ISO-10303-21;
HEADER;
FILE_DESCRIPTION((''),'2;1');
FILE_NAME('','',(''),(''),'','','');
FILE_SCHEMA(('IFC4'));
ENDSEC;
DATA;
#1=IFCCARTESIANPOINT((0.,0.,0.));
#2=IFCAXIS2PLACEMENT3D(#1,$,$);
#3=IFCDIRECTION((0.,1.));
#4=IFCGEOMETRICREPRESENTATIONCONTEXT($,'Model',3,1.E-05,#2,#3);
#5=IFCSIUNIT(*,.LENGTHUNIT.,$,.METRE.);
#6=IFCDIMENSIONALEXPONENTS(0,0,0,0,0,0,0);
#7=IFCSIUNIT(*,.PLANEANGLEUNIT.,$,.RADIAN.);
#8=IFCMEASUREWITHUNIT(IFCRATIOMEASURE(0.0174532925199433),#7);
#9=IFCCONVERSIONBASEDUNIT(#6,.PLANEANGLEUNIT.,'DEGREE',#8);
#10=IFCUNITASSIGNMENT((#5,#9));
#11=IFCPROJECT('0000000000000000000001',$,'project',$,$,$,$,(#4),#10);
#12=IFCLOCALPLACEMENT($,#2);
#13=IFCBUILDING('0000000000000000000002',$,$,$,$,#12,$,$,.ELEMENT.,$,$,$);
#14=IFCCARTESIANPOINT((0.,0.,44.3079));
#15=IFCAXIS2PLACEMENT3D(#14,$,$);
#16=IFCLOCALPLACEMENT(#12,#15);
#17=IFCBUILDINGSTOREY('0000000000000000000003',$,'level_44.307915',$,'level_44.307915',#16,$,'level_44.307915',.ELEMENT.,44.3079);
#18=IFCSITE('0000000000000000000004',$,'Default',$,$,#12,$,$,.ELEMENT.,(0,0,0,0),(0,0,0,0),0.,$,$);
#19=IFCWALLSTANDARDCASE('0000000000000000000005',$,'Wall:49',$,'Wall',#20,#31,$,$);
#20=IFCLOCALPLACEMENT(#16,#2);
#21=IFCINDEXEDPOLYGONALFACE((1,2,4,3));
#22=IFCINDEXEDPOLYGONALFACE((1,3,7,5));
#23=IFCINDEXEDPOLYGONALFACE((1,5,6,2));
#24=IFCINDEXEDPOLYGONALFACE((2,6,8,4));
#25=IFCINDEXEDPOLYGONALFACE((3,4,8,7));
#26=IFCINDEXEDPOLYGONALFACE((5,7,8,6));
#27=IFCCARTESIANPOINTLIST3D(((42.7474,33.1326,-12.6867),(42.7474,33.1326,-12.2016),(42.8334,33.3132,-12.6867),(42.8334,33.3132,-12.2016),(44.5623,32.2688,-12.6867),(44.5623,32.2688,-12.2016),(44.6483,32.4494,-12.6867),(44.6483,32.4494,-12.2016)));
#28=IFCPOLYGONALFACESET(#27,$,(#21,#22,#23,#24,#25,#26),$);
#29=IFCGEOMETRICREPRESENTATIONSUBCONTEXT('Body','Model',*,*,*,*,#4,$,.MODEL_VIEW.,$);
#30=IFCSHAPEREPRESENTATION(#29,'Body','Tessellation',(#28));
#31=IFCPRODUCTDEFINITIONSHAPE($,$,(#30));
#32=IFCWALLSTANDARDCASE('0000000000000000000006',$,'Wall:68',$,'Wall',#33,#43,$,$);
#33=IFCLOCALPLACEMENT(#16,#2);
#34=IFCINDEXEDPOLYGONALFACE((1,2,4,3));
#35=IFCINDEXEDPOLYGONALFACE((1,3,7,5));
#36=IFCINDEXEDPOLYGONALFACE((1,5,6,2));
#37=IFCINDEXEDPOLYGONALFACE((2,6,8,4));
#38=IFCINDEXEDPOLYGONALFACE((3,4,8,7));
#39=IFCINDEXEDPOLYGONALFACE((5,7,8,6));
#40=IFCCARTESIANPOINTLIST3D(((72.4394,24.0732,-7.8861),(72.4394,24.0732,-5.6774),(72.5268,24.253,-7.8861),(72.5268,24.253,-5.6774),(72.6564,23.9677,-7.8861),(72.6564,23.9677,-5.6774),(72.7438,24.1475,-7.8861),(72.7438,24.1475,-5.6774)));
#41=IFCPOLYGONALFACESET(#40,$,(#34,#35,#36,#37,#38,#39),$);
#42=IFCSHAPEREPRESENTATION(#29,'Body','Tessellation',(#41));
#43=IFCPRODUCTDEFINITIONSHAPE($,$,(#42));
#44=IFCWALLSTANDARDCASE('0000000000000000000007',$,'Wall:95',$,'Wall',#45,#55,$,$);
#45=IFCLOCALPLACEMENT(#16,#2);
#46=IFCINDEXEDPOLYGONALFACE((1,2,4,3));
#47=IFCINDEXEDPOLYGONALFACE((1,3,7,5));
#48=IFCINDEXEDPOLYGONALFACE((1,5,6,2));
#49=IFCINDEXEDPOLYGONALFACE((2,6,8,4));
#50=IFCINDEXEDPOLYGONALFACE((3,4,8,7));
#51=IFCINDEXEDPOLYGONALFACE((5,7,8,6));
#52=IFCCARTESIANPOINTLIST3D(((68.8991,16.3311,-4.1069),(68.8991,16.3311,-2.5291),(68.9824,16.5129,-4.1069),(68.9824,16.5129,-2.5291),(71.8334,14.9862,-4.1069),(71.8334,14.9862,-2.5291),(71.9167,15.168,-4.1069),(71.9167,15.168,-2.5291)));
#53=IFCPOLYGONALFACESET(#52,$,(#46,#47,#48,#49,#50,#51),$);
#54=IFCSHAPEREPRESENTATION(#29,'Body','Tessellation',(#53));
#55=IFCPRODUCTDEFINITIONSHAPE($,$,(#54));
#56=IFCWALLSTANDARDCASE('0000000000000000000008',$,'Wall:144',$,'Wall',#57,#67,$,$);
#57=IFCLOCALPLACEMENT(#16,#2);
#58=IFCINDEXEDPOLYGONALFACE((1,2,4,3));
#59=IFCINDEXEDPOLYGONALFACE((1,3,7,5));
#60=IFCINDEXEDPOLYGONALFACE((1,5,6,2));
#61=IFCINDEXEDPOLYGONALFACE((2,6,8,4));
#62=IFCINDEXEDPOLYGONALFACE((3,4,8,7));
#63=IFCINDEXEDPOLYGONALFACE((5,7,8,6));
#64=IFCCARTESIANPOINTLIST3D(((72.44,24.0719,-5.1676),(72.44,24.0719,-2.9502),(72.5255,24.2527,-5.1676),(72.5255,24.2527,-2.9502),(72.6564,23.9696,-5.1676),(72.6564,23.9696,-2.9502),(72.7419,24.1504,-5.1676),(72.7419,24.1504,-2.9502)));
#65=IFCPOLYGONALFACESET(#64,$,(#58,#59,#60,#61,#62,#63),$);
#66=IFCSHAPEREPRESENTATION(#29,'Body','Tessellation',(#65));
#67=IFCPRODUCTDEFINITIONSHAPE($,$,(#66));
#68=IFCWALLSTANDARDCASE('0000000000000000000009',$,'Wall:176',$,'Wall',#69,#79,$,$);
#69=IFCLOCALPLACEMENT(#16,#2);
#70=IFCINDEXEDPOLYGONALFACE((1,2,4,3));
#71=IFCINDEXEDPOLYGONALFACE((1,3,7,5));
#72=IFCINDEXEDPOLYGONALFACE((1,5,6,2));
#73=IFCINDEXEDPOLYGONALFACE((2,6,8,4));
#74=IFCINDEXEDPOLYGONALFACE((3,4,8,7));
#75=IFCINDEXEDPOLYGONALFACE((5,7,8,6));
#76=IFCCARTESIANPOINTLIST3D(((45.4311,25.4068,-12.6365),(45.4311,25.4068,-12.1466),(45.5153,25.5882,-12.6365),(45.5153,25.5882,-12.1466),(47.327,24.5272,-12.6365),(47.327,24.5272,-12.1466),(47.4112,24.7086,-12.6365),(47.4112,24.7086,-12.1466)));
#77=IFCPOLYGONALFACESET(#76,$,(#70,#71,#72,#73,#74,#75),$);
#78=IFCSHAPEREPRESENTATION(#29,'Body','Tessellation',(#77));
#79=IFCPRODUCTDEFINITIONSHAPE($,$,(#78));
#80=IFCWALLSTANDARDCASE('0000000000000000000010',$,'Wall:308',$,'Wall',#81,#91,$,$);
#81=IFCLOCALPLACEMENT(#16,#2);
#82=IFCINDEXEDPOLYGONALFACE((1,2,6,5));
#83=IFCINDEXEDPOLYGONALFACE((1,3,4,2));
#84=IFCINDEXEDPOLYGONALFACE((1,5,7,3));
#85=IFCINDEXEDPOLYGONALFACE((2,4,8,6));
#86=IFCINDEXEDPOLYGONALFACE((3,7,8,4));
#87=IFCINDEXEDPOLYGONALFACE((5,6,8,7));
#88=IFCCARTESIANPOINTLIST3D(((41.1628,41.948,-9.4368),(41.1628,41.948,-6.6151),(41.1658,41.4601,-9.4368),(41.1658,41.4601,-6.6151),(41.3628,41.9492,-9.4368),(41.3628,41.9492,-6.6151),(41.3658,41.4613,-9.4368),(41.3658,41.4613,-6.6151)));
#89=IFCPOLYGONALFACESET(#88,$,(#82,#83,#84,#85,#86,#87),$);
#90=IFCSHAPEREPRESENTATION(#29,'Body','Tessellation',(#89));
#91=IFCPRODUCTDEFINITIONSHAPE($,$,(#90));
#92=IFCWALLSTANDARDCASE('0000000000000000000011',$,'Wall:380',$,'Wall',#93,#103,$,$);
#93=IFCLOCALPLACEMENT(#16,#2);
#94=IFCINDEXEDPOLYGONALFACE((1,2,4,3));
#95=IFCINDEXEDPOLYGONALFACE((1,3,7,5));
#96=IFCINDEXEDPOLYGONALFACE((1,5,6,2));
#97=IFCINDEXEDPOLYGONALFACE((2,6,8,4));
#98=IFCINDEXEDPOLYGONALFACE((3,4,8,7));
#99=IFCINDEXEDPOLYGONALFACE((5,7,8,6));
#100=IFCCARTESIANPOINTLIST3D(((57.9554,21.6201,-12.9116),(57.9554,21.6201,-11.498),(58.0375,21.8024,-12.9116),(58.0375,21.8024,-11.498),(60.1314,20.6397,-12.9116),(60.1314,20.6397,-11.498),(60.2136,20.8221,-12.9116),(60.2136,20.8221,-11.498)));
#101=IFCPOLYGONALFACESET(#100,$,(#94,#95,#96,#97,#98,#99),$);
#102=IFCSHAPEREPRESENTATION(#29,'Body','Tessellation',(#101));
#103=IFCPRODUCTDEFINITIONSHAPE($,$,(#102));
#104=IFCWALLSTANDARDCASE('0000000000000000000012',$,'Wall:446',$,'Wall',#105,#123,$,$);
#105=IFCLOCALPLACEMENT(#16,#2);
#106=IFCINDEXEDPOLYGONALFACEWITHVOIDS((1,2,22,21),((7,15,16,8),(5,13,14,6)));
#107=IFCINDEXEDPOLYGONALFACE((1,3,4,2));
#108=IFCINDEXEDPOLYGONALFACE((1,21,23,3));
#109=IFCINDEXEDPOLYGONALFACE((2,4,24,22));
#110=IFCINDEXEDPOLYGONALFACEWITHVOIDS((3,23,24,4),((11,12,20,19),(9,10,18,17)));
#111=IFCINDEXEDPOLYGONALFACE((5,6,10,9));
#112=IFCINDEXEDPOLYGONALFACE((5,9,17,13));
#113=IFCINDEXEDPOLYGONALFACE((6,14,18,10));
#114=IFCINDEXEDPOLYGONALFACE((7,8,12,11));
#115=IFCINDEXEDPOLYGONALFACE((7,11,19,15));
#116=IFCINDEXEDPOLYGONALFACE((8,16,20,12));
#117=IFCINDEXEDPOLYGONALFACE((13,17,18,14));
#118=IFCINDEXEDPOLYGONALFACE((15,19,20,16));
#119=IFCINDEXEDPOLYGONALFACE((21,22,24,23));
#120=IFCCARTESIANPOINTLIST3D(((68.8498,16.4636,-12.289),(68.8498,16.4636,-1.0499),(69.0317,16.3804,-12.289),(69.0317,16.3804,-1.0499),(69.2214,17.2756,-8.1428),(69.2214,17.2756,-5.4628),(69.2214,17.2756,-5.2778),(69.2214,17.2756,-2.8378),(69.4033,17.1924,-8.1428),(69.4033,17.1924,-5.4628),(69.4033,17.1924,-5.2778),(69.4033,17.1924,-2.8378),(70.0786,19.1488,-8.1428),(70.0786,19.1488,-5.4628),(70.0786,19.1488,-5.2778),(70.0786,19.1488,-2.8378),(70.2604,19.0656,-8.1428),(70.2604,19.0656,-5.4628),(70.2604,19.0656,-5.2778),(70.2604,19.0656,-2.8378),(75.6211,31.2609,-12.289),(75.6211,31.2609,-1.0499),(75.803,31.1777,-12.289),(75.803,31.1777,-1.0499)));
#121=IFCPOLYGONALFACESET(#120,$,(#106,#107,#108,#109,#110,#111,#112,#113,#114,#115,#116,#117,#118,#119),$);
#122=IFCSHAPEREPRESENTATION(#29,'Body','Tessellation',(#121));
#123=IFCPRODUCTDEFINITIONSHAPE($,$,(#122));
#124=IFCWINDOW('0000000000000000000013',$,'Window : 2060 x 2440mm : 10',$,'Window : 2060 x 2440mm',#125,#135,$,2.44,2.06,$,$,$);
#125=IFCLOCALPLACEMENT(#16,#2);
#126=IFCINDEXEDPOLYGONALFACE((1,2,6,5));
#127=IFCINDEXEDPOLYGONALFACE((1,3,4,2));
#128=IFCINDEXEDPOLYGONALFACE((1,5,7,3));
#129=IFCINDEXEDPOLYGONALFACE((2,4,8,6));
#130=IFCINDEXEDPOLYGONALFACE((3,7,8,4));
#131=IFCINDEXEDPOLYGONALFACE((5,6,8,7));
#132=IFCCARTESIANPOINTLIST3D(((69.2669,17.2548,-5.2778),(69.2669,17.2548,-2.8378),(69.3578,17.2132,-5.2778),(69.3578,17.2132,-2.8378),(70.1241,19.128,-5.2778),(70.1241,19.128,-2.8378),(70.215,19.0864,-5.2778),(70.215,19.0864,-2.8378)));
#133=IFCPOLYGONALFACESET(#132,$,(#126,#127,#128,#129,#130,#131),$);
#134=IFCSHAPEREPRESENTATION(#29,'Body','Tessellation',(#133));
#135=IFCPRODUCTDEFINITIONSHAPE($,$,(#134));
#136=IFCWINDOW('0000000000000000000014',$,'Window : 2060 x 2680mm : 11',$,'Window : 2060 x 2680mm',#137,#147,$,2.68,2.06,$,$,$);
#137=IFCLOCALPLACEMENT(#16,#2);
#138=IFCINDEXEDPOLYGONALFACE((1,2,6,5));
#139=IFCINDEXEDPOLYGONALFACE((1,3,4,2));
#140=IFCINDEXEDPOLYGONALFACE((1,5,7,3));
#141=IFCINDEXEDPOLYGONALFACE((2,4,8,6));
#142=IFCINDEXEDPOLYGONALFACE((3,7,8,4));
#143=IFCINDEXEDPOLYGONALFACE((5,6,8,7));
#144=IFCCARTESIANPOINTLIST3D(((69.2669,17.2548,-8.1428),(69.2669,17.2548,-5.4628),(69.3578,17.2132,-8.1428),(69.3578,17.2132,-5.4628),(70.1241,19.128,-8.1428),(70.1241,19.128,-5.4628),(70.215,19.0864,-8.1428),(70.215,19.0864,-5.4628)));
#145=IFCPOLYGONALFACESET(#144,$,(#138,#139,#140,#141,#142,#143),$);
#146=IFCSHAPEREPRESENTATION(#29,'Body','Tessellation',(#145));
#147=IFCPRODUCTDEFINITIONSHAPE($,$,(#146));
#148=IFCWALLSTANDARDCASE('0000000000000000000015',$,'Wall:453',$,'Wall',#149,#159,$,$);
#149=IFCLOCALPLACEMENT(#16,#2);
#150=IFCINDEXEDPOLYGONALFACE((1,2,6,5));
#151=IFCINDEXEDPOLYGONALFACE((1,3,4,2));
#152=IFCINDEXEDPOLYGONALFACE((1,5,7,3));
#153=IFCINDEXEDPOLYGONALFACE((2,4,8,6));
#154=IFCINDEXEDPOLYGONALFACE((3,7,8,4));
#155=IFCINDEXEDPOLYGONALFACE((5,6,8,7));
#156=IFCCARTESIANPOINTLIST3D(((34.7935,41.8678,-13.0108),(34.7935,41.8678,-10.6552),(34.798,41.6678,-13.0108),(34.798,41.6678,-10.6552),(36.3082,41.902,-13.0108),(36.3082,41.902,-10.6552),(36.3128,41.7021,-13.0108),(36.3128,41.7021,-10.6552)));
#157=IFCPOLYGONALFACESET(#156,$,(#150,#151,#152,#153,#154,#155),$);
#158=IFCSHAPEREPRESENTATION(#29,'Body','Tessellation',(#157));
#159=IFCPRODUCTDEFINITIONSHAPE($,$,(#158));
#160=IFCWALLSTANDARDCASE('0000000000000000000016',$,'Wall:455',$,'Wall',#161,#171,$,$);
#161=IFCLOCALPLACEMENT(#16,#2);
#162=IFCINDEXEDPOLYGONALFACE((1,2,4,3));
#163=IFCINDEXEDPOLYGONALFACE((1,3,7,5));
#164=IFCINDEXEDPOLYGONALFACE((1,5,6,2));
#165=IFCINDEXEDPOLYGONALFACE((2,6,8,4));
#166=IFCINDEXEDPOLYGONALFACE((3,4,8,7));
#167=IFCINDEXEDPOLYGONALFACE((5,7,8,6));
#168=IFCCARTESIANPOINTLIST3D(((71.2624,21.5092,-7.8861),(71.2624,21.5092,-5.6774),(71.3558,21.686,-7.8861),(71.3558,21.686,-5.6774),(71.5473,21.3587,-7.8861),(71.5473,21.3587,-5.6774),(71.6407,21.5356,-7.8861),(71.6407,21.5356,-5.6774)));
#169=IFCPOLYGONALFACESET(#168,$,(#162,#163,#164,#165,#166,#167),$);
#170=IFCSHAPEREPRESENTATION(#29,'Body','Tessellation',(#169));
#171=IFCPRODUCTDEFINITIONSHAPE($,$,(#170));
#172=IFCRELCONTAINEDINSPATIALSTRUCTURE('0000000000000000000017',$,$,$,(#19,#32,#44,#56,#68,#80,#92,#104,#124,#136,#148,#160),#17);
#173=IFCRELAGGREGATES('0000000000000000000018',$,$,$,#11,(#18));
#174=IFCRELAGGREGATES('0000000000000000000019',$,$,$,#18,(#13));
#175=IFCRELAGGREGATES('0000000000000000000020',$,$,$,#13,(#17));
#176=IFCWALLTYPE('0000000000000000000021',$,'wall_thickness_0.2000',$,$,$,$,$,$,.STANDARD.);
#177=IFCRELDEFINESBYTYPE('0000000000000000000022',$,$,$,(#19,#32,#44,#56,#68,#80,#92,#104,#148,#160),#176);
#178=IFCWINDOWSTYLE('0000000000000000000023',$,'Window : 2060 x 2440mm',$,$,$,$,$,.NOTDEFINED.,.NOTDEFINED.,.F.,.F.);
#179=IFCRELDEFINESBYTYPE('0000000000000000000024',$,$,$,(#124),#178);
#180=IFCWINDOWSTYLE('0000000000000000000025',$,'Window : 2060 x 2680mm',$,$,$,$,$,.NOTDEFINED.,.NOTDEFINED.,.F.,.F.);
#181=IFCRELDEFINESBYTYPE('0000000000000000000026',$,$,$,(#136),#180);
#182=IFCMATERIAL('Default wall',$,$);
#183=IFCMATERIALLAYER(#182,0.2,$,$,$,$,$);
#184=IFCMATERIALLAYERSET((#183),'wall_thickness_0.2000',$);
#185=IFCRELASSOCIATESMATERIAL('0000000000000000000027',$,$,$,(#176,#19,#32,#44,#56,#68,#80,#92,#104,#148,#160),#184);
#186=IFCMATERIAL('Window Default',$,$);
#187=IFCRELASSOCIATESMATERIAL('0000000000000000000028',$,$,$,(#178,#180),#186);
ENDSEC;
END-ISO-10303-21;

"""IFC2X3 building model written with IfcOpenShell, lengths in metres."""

from ifc_helpers import new_model, entity, si_unit, converted_unit, direction, frame, frame_2d, origin, origin_2d_with_axis, place, context, subcontext, project, spatial, polyline, rectangle, outline, extrude, source, transform, mapped, material, layer, layer_set, layer_usage, type_object, type_shapes, element, fill, save


model = new_model("IFC2X3")

# Units and contexts
model_context = context("Model", 3, precision=1e-05, world=origin(), true_north=direction((0.0, 1.0)))
body_context = subcontext(model_context, "Body", "Model", "MODEL_VIEW")
ifc_project = project(units=[si_unit("LENGTHUNIT", "METRE"), converted_unit("PLANEANGLEUNIT", "DEGREE", entity("IfcRatioMeasure", 0.0174532925199433), si_unit("PLANEANGLEUNIT", "RADIAN"), dimensions=[0, 0, 0, 0, 0, 0, 0])], contexts=[model_context])

# Site, building, storey
placement_1 = place(None, origin())
site = spatial("IfcSite", under=ifc_project, at=placement_1, Name="Default", CompositionType="ELEMENT", RefLatitude=(0, 0, 0, 0), RefLongitude=(0, 0, 0, 0), RefElevation=0.0)
building = spatial("IfcBuilding", under=site, at=placement_1, CompositionType="ELEMENT")
storey_placement = place(placement_1, frame((0.0, 0.0, 44.3079)))
storey = spatial("IfcBuildingStorey", under=building, at=storey_placement, Name="level_44.307915", ObjectType="level_44.307915", LongName="level_44.307915", CompositionType="ELEMENT", Elevation=44.3079)

# Walls
ifc_material_1 = material(Name="Default wall")
ifc_layer = layer(ifc_material_1, 0.2)
ifc_layer_set = layer_set([ifc_layer], Name="wall_thickness_0.2000")
ifc_layer_usage = layer_usage(ifc_layer_set, "AXIS2", "POSITIVE", -0.1)
wall_type = type_object("IfcWallType", Name="wall_thickness_0.2000", PredefinedType="STANDARD", material=ifc_layer_set)
placement_2 = place(placement_1, frame((0.0, 0.0, 31.6212)))
wall_1_placement = place(placement_2, frame((42.7904, 33.2229, 0.0), z_axis=(0.0, 0.0, 1.0), x_axis=(0.902938, -0.429772, 0.0)))
element("IfcWallStandardCase", 1, at=wall_1_placement, inside=storey, type_object=wall_type, material=ifc_layer_usage, Name="Wall:49", ObjectType="Wall", context=body_context, shape_type="SweptSolid", body=[
    extrude(outline(polyline([(2.01, -0.1), (2.01, 0.1), (0.0, 0.1), (0.0, -0.1), (2.01, -0.1)])), origin(), (0.0, 0.0, 1.0), 0.485),
])
placement_3 = place(placement_1, frame((0.0, 0.0, 36.4218)))
wall_2_placement = place(placement_3, frame((72.4831, 24.1631, 0.0), z_axis=(0.0, 0.0, 1.0), x_axis=(0.899364, -0.4372, 0.0)))
element("IfcWallStandardCase", 2, at=wall_2_placement, inside=storey, type_object=wall_type, material=ifc_layer_usage, Name="Wall:68", ObjectType="Wall", context=body_context, shape_type="SweptSolid", body=[
    extrude(outline(polyline([(0.2413, -0.1), (0.2413, 0.1), (0.0, 0.1), (0.0, -0.1), (0.2413, -0.1)])), origin(), (0.0, 0.0, 1.0), 2.2087),
])
placement_4 = place(placement_1, frame((0.0, 0.0, 40.201)))
wall_3_placement = place(placement_4, frame((68.9408, 16.422, 0.0), z_axis=(0.0, 0.0, 1.0), x_axis=(0.90906, -0.416665, 0.0)))
element("IfcWallStandardCase", 3, at=wall_3_placement, inside=storey, type_object=wall_type, material=ifc_layer_usage, Name="Wall:95", ObjectType="Wall", context=body_context, shape_type="SweptSolid", body=[
    extrude(outline(polyline([(3.2278, -0.1), (3.2278, 0.1), (0.0, 0.1), (0.0, -0.1), (3.2278, -0.1)])), origin(), (0.0, 0.0, 1.0), 1.5778),
])
placement_5 = place(placement_1, frame((0.0, 0.0, 39.1403)))
wall_4_placement = place(placement_5, frame((72.4828, 24.1623, 0.0), z_axis=(0.0, 0.0, 1.0), x_axis=(0.903995, -0.427543, 0.0)))
element("IfcWallStandardCase", 4, at=wall_4_placement, inside=storey, type_object=wall_type, material=ifc_layer_usage, Name="Wall:144", ObjectType="Wall", context=body_context, shape_type="SweptSolid", body=[
    extrude(outline(polyline([(0.2394, -0.1), (0.2394, 0.1), (0.0, 0.1), (0.0, -0.1), (0.2394, -0.1)])), origin(), (0.0, 0.0, 1.0), 2.2174),
])
placement_6 = place(placement_1, frame((0.0, 0.0, 31.6714)))
wall_5_placement = place(placement_6, frame((45.4732, 25.4975, 0.0), z_axis=(0.0, 0.0, 1.0), x_axis=(0.907125, -0.42086, 0.0)))
element("IfcWallStandardCase", 5, at=wall_5_placement, inside=storey, type_object=wall_type, material=ifc_layer_usage, Name="Wall:176", ObjectType="Wall", context=body_context, shape_type="SweptSolid", body=[
    extrude(outline(polyline([(2.09, -0.1), (2.09, 0.1), (0.0, 0.1), (0.0, -0.1), (2.09, -0.1)])), origin(), (0.0, 0.0, 1.0), 0.4899),
])
placement_7 = place(placement_1, frame((0.0, 0.0, 34.8711)))
wall_6_placement = place(placement_7, frame((41.2628, 41.9486, 0.0), z_axis=(0.0, 0.0, 1.0), x_axis=(0.006059, -0.999982, 0.0)))
element("IfcWallStandardCase", 6, at=wall_6_placement, inside=storey, type_object=wall_type, material=ifc_layer_usage, Name="Wall:308", ObjectType="Wall", context=body_context, shape_type="SweptSolid", body=[
    extrude(outline(polyline([(0.4879, -0.1), (0.4879, 0.1), (0.0, 0.1), (0.0, -0.1), (0.4879, -0.1)])), origin(), (0.0, 0.0, 1.0), 2.8217),
])
placement_8 = place(placement_1, frame((0.0, 0.0, 31.3963)))
wall_7_placement = place(placement_8, frame((57.9964, 21.7113, 0.0), z_axis=(0.0, 0.0, 1.0), x_axis=(0.911743, -0.410761, 0.0)))
element("IfcWallStandardCase", 7, at=wall_7_placement, inside=storey, type_object=wall_type, material=ifc_layer_usage, Name="Wall:380", ObjectType="Wall", context=body_context, shape_type="SweptSolid", body=[
    extrude(outline(polyline([(2.3867, -0.1), (2.3867, 0.1), (0.0, 0.1), (0.0, -0.1), (2.3867, -0.1)])), origin(), (0.0, 0.0, 1.0), 1.4136),
])

# Wall, openings, windows
placement_9 = place(placement_1, frame((0.0, 0.0, 32.0189)))
wall_8_placement = place(placement_9, frame((68.9408, 16.422, 0.0), z_axis=(0.0, 0.0, 1.0), x_axis=(0.416104, 0.909317, 0.0)))
wall_8 = element("IfcWallStandardCase", 8, at=wall_8_placement, inside=storey, type_object=wall_type, material=ifc_layer_usage, Name="Wall:446", ObjectType="Wall", context=body_context, shape_type="SweptSolid", body=[
    extrude(outline(polyline([(16.273, -0.1), (16.273, 0.1), (0.0, 0.1), (0.0, -0.1), (16.273, -0.1)])), origin(), (0.0, 0.0, 1.0), 11.2391),
])
opening_1_placement = place(wall_8_placement, frame((0.893, -0.1, 7.0112)))
opening_1 = element("IfcOpeningElement", 9, at=opening_1_placement, cuts=wall_8, ObjectType="Opening", context=body_context, shape_type="SweptSolid", body=[
    extrude(rectangle(XDim=2.06, YDim=2.44, at=frame_2d((1.22, 1.03), x_axis=(0.0, 1.0))), frame((0.0, 0.0, 0.0), z_axis=(0.0, 1.0, 0.0), x_axis=(0.0, 0.0, 1.0)), (0.0, 0.0, 1.0), 0.2),
])
opening_2_placement = place(wall_8_placement, frame((0.893, -0.1, 4.1462)))
opening_2 = element("IfcOpeningElement", 10, at=opening_2_placement, cuts=wall_8, ObjectType="Opening", context=body_context, shape_type="SweptSolid", body=[
    extrude(rectangle(XDim=2.06, YDim=2.68, at=frame_2d((1.34, 1.03), x_axis=(0.0, 1.0))), frame((0.0, 0.0, 0.0), z_axis=(0.0, 1.0, 0.0), x_axis=(0.0, 0.0, 1.0)), (0.0, 0.0, 1.0), 0.2),
])
ifc_material_2 = material(Name="Window Default")
window_style_1 = type_object("IfcWindowStyle", Name="Window : 2060 x 2440mm", ConstructionType="NOTDEFINED", OperationType="NOTDEFINED", ParameterTakesPrecedence=False, Sizeable=False, material=ifc_material_2)
shared_shape_1 = source(origin(), body_context, "Body", "SweptSolid", [
    extrude(rectangle(XDim=0.1, YDim=2.06, at=origin_2d_with_axis()), frame((1.03, 0.1, 0.0), z_axis=(0.0, 0.0, 1.0), x_axis=(0.0, 1.0, 0.0)), (0.0, 0.0, 1.0), 2.44),
])
type_shapes(window_style_1, [shared_shape_1])
window_1_placement = place(opening_1_placement, origin())
window_1 = element("IfcWindow", 11, at=window_1_placement, inside=storey, type_object=window_style_1, Name="Window : 2060 x 2440mm : 10", ObjectType="Window : 2060 x 2440mm", OverallHeight=2.44, OverallWidth=2.06, context=body_context, shape_type="MappedRepresentation", body=[
    mapped(shared_shape_1, transform((0.0, 0.0, 0.0), scale=1.0)),
])
fill(opening_1, window_1)
window_style_2 = type_object("IfcWindowStyle", Name="Window : 2060 x 2680mm", ConstructionType="NOTDEFINED", OperationType="NOTDEFINED", ParameterTakesPrecedence=False, Sizeable=False, material=ifc_material_2)
shared_shape_2 = source(origin(), body_context, "Body", "SweptSolid", [
    extrude(rectangle(XDim=0.1, YDim=2.06, at=origin_2d_with_axis()), frame((1.03, 0.1, 0.0), z_axis=(0.0, 0.0, 1.0), x_axis=(0.0, 1.0, 0.0)), (0.0, 0.0, 1.0), 2.68),
])
type_shapes(window_style_2, [shared_shape_2])
window_2_placement = place(opening_2_placement, origin())
window_2 = element("IfcWindow", 12, at=window_2_placement, inside=storey, type_object=window_style_2, Name="Window : 2060 x 2680mm : 11", ObjectType="Window : 2060 x 2680mm", OverallHeight=2.68, OverallWidth=2.06, context=body_context, shape_type="MappedRepresentation", body=[
    mapped(shared_shape_2, transform((0.0, 0.0, 0.0), scale=1.0)),
])
fill(opening_2, window_2)

# Walls
placement_10 = place(placement_1, frame((0.0, 0.0, 31.2971)))
wall_9_placement = place(placement_10, frame((36.3105, 41.802, 0.0), z_axis=(0.0, 0.0, 1.0), x_axis=(-0.999744, -0.022604, 0.0)))
element("IfcWallStandardCase", 13, at=wall_9_placement, inside=storey, type_object=wall_type, material=ifc_layer_usage, Name="Wall:453", ObjectType="Wall", context=body_context, shape_type="SweptSolid", body=[
    extrude(outline(polyline([(1.5151, -0.1), (1.5151, 0.1), (0.0, 0.1), (0.0, -0.1), (1.5151, -0.1)])), origin(), (0.0, 0.0, 1.0), 2.3557),
])
placement_11 = place(placement_1, frame((0.0, 0.0, 36.4218)))
wall_10_placement = place(placement_11, frame((71.594, 21.4471, 0.0), z_axis=(0.0, 0.0, 1.0), x_axis=(-0.88428, 0.466958, 0.0)))
element("IfcWallStandardCase", 14, at=wall_10_placement, inside=storey, type_object=wall_type, material=ifc_layer_usage, Name="Wall:455", ObjectType="Wall", context=body_context, shape_type="SweptSolid", body=[
    extrude(outline(polyline([(0.3222, -0.1), (0.3222, 0.1), (0.0, 0.1), (0.0, -0.1), (0.3222, -0.1)])), origin(), (0.0, 0.0, 1.0), 2.2087),
])

save(model, "model.ifc")
